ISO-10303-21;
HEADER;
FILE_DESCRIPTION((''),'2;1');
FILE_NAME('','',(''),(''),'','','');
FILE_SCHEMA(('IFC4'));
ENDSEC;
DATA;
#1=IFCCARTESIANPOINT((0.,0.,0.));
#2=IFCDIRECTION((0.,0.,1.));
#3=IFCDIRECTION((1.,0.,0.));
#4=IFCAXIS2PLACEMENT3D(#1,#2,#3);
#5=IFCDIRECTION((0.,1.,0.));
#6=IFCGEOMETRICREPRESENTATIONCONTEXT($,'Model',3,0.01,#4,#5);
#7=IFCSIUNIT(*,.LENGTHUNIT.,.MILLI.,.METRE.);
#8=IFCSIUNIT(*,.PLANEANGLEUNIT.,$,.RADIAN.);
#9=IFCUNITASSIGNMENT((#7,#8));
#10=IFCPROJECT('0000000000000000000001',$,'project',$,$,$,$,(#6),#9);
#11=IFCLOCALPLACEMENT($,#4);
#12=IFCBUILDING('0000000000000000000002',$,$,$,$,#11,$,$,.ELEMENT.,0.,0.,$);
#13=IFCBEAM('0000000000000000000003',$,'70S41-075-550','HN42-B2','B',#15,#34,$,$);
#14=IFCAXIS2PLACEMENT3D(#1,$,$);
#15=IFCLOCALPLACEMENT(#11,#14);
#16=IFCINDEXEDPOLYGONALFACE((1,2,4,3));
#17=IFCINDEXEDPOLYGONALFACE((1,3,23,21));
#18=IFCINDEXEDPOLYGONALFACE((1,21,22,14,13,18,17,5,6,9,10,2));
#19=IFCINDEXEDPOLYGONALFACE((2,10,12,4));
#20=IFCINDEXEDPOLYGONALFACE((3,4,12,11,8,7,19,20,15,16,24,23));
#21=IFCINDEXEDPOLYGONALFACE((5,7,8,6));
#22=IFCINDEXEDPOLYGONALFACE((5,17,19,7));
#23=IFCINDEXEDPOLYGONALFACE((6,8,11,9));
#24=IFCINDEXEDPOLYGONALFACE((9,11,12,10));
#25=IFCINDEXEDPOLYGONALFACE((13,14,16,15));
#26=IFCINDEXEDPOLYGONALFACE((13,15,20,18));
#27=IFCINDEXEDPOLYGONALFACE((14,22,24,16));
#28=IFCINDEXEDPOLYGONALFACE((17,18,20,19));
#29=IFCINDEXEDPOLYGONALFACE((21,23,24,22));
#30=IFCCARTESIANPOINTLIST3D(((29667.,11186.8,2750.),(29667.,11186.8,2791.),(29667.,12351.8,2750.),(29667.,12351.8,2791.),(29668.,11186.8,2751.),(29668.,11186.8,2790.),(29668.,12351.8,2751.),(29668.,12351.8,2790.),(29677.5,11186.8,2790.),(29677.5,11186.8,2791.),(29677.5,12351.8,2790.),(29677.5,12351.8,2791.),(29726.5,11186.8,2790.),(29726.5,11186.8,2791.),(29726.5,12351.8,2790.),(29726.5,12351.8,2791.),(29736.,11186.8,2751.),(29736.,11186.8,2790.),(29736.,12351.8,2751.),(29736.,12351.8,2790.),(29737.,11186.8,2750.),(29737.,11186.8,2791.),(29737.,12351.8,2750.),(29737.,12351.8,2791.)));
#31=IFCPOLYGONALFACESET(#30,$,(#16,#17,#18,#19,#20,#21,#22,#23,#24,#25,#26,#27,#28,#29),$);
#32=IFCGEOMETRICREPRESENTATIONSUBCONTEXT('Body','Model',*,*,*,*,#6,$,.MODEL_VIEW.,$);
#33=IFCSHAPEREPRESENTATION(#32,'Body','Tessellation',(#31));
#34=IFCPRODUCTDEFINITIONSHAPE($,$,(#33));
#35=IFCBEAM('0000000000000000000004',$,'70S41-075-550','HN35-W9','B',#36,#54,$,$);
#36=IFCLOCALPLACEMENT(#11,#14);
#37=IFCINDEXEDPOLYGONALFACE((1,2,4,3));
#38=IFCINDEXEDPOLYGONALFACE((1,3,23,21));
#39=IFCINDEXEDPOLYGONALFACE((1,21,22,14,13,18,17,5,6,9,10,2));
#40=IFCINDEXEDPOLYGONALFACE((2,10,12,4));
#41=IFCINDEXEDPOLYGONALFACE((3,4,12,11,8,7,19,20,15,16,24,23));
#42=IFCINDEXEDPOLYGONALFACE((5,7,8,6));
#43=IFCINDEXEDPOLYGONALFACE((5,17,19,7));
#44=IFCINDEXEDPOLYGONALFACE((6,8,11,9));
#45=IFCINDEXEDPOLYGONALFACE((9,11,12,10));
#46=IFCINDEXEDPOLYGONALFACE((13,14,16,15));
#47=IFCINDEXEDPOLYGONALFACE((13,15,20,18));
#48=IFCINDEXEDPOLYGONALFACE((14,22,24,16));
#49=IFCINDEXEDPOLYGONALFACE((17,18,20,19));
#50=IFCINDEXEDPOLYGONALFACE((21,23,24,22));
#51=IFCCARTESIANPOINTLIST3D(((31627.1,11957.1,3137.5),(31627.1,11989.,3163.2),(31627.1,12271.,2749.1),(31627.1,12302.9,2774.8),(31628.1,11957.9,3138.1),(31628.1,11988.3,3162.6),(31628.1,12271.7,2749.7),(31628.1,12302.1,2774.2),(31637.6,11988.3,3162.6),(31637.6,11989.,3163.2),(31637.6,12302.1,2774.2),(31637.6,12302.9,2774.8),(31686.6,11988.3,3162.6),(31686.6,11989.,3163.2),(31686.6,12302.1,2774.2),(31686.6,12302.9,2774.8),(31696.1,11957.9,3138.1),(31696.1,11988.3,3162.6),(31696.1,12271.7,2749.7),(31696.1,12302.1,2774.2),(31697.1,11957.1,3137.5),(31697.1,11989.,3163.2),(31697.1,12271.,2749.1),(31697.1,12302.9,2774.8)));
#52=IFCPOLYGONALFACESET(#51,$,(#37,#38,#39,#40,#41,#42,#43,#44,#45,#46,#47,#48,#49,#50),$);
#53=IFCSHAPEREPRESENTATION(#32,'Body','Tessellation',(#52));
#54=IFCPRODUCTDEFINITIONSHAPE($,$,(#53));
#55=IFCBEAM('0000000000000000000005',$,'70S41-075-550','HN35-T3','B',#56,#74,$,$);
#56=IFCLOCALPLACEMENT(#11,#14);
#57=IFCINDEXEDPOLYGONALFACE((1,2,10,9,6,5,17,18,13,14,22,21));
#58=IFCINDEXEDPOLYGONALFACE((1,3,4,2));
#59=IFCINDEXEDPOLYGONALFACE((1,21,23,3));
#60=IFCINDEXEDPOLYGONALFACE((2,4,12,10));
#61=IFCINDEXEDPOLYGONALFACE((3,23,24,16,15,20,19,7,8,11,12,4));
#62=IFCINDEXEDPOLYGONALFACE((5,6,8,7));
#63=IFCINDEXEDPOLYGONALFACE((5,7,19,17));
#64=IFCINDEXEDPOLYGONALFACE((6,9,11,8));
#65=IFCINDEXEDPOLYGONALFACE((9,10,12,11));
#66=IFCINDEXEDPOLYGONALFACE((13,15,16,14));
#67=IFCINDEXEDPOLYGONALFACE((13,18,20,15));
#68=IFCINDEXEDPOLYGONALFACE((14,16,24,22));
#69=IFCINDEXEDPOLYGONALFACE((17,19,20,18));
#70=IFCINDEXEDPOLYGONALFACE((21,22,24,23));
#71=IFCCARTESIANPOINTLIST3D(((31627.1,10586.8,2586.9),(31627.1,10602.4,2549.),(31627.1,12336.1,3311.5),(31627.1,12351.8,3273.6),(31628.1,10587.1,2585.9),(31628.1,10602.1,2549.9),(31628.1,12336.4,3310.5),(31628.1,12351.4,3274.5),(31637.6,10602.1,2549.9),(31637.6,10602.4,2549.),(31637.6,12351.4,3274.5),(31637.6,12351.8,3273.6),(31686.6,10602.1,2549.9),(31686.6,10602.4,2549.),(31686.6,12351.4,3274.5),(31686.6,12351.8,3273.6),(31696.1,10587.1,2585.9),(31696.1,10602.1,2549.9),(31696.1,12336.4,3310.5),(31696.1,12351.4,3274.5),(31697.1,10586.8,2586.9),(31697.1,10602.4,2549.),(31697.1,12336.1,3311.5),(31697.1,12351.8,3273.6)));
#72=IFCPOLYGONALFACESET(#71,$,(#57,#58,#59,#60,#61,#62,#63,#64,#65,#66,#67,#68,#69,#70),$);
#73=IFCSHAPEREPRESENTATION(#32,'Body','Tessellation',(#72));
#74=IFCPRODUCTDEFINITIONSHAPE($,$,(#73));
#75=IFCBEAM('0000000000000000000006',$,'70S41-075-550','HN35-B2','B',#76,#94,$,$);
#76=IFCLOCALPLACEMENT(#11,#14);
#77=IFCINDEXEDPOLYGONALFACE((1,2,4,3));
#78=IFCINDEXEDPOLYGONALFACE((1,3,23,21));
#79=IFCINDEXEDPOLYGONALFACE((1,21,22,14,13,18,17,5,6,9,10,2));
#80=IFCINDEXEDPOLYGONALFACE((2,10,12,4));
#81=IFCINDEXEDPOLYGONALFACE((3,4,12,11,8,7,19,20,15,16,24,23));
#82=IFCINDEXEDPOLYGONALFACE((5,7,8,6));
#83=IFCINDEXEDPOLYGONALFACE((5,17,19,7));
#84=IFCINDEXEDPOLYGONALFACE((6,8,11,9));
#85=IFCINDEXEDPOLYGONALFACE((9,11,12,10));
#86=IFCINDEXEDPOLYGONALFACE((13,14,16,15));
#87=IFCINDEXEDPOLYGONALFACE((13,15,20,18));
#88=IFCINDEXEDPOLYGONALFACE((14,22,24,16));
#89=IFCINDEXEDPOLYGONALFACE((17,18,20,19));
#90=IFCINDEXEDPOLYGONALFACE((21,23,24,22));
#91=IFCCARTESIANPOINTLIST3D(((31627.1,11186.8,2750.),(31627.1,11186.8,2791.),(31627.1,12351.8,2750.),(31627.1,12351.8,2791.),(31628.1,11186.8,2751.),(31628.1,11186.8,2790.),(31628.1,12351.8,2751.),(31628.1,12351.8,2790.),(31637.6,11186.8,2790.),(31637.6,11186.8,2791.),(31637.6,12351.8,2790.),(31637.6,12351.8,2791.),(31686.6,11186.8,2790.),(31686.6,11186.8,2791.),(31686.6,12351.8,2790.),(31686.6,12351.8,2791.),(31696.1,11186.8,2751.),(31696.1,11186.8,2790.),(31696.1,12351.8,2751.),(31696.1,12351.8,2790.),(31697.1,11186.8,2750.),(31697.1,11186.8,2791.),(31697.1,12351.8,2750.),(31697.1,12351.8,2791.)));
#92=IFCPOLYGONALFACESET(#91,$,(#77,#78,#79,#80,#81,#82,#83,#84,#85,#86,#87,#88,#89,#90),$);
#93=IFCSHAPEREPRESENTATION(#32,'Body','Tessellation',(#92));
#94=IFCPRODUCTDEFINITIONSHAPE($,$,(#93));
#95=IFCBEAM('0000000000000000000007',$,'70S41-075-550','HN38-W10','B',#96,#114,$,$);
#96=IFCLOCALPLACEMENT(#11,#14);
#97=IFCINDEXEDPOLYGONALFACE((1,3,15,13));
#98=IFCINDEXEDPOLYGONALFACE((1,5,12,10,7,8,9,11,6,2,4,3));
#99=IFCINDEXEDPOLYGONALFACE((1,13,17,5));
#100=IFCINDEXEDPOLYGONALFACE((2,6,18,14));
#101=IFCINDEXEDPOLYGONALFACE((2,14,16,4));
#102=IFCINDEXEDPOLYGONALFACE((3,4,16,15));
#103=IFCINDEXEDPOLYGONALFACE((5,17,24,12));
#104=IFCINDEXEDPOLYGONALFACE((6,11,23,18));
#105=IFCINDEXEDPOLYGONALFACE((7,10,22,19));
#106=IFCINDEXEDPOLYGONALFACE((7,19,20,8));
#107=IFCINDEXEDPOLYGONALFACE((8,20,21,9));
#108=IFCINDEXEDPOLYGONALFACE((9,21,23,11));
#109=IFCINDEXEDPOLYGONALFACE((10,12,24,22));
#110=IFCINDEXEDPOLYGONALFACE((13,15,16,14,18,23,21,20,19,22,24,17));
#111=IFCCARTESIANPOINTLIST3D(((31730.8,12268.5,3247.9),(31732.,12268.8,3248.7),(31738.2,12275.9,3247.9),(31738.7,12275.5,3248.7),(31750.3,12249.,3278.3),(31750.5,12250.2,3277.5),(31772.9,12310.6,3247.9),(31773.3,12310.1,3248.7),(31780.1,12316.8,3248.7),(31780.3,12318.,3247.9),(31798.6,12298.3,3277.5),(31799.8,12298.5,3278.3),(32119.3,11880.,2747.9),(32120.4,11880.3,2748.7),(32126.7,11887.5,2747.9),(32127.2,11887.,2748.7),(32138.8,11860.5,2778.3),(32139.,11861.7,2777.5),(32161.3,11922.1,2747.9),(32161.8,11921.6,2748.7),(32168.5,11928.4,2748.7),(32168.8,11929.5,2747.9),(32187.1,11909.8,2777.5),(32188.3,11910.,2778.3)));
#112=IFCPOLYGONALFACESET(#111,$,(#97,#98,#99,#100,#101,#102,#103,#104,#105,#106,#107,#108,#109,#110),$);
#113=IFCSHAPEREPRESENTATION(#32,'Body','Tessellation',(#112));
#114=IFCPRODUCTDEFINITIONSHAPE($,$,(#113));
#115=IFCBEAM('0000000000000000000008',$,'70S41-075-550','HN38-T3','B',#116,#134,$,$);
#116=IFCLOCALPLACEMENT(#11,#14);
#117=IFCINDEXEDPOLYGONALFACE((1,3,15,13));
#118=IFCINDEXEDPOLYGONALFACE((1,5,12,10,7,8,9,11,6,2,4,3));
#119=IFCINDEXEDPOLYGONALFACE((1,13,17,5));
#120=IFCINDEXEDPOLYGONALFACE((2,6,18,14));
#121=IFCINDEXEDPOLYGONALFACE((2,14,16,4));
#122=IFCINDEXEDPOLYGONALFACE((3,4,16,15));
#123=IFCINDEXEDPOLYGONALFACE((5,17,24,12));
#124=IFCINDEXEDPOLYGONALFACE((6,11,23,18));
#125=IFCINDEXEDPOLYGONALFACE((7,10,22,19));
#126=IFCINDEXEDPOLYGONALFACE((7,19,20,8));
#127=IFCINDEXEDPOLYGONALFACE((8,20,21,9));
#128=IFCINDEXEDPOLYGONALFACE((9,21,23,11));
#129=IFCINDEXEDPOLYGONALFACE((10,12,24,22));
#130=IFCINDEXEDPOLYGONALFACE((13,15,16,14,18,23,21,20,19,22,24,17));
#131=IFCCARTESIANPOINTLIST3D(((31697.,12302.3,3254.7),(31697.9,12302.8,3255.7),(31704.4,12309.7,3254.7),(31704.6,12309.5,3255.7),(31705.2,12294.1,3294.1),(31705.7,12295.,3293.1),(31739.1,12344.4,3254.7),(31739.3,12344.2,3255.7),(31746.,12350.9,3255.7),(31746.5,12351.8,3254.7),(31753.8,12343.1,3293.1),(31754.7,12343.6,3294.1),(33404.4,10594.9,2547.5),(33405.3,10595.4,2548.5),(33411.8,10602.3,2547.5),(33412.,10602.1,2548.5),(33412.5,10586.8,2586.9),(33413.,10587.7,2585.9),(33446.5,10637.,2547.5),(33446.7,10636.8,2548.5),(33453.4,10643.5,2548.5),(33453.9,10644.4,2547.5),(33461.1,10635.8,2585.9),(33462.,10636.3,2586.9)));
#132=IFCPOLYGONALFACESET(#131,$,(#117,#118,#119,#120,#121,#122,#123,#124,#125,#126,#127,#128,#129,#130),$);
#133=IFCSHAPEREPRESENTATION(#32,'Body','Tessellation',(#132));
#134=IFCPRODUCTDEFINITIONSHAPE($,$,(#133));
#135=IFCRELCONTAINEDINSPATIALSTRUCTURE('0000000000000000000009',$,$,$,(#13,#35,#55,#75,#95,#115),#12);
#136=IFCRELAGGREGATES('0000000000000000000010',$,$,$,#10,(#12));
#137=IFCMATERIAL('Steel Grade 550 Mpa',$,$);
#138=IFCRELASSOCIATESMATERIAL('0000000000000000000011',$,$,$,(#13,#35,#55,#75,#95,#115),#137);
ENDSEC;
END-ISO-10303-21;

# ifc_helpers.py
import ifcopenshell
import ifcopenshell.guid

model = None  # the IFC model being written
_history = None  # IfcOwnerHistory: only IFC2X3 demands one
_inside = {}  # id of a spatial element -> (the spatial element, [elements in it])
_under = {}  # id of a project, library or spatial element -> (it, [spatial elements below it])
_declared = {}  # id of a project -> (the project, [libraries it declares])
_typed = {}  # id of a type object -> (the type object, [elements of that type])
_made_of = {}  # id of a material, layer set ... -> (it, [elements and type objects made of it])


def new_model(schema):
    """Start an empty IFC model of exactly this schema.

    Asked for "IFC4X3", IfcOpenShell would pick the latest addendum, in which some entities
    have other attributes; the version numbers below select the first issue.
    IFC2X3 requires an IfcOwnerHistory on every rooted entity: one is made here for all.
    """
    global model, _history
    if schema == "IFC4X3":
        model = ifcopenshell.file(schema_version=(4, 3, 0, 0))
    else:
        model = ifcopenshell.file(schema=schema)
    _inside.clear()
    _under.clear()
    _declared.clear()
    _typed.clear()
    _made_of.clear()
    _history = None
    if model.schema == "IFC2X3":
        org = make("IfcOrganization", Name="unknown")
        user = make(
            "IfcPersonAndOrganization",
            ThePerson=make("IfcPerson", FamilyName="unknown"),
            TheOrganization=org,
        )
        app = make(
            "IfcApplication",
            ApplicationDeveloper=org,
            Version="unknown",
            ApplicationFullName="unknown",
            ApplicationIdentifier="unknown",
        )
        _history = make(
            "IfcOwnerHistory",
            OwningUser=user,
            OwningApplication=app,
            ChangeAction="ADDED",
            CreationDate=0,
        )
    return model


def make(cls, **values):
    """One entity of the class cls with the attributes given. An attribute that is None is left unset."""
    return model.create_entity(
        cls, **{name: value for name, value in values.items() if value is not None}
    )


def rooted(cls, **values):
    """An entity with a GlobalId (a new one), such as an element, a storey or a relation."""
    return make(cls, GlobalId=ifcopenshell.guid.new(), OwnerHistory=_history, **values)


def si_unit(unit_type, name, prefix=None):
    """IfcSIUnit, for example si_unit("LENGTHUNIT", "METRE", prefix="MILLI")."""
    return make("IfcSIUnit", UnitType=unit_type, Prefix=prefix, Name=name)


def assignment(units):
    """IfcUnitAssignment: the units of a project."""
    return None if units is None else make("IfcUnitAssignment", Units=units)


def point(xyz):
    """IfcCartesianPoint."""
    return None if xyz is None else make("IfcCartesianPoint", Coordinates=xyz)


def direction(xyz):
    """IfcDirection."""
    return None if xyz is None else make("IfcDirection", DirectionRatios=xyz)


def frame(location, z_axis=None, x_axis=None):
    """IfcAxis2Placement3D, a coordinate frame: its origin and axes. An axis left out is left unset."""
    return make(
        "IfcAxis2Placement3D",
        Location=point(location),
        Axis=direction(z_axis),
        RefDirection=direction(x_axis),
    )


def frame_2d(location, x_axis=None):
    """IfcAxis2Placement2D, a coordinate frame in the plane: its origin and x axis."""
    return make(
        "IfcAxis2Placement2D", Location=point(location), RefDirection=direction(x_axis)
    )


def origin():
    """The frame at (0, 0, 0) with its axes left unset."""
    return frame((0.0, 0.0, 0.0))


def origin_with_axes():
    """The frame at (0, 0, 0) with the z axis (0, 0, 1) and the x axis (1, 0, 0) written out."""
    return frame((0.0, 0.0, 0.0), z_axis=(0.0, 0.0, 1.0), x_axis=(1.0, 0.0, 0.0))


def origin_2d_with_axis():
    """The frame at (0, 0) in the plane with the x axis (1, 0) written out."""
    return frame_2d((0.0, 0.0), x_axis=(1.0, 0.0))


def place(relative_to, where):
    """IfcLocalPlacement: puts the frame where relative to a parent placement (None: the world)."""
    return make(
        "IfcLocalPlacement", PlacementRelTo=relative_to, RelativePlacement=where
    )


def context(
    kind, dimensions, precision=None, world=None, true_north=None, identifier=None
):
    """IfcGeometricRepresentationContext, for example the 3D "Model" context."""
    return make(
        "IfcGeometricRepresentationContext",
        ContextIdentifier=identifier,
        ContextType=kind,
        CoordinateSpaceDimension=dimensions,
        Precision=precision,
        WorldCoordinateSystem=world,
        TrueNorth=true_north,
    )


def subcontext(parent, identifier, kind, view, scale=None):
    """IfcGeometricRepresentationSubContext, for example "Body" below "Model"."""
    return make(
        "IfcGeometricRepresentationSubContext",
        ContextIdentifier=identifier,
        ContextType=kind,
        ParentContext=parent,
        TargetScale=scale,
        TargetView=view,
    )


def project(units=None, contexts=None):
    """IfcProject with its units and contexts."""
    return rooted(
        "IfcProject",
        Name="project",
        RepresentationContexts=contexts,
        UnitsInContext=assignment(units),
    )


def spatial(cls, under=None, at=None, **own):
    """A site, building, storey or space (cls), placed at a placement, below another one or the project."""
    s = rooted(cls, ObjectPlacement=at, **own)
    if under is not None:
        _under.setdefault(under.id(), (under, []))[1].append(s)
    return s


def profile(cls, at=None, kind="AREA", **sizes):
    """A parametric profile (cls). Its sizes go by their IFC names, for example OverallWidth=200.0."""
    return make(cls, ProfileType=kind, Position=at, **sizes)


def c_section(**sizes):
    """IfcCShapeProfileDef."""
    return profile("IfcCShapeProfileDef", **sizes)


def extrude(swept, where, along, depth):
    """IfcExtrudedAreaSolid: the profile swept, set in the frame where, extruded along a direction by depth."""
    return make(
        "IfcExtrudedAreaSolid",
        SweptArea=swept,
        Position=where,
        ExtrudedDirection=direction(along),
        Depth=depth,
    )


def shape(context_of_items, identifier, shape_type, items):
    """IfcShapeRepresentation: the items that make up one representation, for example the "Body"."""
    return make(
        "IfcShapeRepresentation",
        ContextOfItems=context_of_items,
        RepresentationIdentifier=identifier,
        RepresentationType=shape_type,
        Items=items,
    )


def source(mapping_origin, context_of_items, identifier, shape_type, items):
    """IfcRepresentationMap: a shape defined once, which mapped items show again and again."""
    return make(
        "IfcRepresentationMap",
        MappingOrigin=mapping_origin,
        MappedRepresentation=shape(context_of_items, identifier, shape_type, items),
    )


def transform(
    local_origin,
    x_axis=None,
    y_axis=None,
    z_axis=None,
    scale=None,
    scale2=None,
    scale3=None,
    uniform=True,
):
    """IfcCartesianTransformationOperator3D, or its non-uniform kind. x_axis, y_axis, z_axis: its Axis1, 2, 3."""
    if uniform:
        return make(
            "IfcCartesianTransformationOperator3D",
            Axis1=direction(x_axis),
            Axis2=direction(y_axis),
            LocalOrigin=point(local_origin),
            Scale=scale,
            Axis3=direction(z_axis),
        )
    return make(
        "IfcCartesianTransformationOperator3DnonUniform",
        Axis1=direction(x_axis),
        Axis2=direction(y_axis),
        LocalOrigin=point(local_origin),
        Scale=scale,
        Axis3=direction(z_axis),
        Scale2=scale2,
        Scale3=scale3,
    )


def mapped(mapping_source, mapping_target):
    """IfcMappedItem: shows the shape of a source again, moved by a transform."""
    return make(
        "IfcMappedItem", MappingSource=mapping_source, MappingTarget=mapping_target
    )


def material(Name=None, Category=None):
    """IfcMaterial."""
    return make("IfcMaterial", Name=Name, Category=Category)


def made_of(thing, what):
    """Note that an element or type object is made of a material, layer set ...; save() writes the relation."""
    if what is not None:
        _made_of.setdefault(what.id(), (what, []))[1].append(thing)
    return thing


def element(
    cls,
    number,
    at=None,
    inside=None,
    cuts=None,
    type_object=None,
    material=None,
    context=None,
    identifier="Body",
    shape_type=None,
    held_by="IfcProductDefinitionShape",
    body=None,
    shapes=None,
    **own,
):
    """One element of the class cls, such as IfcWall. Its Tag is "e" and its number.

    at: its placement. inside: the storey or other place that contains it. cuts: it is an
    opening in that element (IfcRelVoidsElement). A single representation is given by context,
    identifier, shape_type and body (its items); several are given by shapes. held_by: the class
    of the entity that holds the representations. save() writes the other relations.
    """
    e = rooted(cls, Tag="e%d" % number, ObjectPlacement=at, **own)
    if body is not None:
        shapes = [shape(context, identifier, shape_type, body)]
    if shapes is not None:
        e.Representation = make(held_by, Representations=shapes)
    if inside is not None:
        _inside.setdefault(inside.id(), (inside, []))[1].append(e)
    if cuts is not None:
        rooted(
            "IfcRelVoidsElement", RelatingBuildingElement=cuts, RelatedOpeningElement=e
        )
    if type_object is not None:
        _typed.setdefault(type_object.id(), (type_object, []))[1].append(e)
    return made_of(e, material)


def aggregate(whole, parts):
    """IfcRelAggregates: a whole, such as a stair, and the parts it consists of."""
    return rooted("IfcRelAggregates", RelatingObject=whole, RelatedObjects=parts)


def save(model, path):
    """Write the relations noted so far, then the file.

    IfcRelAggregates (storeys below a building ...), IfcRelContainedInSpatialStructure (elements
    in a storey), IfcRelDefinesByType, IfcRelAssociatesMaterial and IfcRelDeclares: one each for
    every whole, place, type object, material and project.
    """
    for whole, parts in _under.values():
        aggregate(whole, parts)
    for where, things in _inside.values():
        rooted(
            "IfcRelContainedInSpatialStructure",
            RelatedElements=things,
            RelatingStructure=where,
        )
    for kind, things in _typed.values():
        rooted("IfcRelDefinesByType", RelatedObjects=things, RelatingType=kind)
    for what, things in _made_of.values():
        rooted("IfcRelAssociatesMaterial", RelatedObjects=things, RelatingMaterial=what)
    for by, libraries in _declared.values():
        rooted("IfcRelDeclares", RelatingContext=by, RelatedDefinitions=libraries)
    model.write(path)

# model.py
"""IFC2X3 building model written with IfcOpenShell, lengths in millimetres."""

from ifc_helpers import new_model, si_unit, direction, frame, origin, origin_with_axes, origin_2d_with_axis, place, context, subcontext, project, spatial, c_section, extrude, source, transform, mapped, material, element, save


model = new_model("IFC2X3")

# Units and contexts
model_context = context("Model", 3, precision=0.01, world=origin_with_axes(), true_north=direction((0.0, 1.0, 0.0)))
body_context = subcontext(model_context, "Body", "Model", "MODEL_VIEW")
ifc_project = project(units=[si_unit("LENGTHUNIT", "METRE", prefix="MILLI"), si_unit("PLANEANGLEUNIT", "RADIAN")], contexts=[model_context])

# Building
building_placement = place(None, origin_with_axes())
building = spatial("IfcBuilding", under=ifc_project, at=building_placement, CompositionType="ELEMENT", ElevationOfRefHeight=0.0, ElevationOfTerrain=0.0)

# Shared definitions
ifc_material = material(Name="Steel Grade 550 Mpa")

# Beams
shared_shape_1 = source(origin(), body_context, "Body", "SweptSolid", [
    extrude(c_section(Depth=70.0, Width=41.0, WallThickness=1.0, Girth=10.5, at=origin_2d_with_axis()), origin_with_axes(), (0.0, 0.0, 1.0), 1165.0),
])
beam_1_placement = place(None, frame((29702.0, 11186.8, 2770.5), z_axis=(0.0, 1.0, 0.0), x_axis=(0.0, 0.0, 1.0)))
element("IfcBeam", 1, at=beam_1_placement, inside=building, material=ifc_material, Name="70S41-075-550", Description="HN42-B2", ObjectType="B", context=body_context, shape_type="MappedRepresentation", body=[
    mapped(shared_shape_1, transform((0.0, 0.0, 0.0), scale=1.0)),
])
shared_shape_2 = source(origin(), body_context, "Body", "SweptSolid", [
    extrude(c_section(Depth=70.0, Width=41.0, WallThickness=1.0, Girth=10.5, at=origin_2d_with_axis()), origin_with_axes(), (0.0, 0.0, 1.0), 499.3),
])
beam_2_placement = place(None, frame((31662.1, 11973.1, 3150.3), z_axis=(0.0, 0.628483, -0.777823), x_axis=(0.0, 0.777823, 0.628483)))
element("IfcBeam", 2, at=beam_2_placement, inside=building, material=ifc_material, Name="70S41-075-550", Description="HN35-W9", ObjectType="B", context=body_context, shape_type="MappedRepresentation", body=[
    mapped(shared_shape_2, transform((0.0, 0.0, 0.0), scale=1.0)),
])
shared_shape_3 = source(origin(), body_context, "Body", "SweptSolid", [
    extrude(c_section(Depth=70.0, Width=41.0, WallThickness=1.0, Girth=10.5, at=origin_2d_with_axis()), origin_with_axes(), (0.0, 0.0, 1.0), 1893.4),
])
beam_3_placement = place(None, frame((31662.1, 12343.9, 3292.5), z_axis=(0.0, -0.92388, -0.382683), x_axis=(0.0, 0.382683, -0.92388)))
element("IfcBeam", 3, at=beam_3_placement, inside=building, material=ifc_material, Name="70S41-075-550", Description="HN35-T3", ObjectType="B", context=body_context, shape_type="MappedRepresentation", body=[
    mapped(shared_shape_3, transform((0.0, 0.0, 0.0), scale=1.0)),
])
shared_shape_4 = source(origin(), body_context, "Body", "SweptSolid", [
    extrude(c_section(Depth=70.0, Width=41.0, WallThickness=1.0, Girth=10.5, at=origin_2d_with_axis()), origin_with_axes(), (0.0, 0.0, 1.0), 1165.0),
])
beam_4_placement = place(None, frame((31662.1, 11186.8, 2770.5), z_axis=(0.0, 1.0, 0.0), x_axis=(0.0, 0.0, 1.0)))
element("IfcBeam", 4, at=beam_4_placement, inside=building, material=ifc_material, Name="70S41-075-550", Description="HN35-B2", ObjectType="B", context=body_context, shape_type="MappedRepresentation", body=[
    mapped(shared_shape_4, transform((0.0, 0.0, 0.0), scale=1.0)),
])
shared_shape_5 = source(origin(), body_context, "Body", "SweptSolid", [
    extrude(c_section(Depth=70.0, Width=41.0, WallThickness=1.0, Girth=10.5, at=origin_2d_with_axis()), origin_with_axes(), (0.0, 0.0, 1.0), 742.9),
])
beam_5_placement = place(None, frame((31765.3, 12283.5, 3263.1), z_axis=(0.522949, -0.522949, -0.673089), x_axis=(-0.475946, 0.475945, -0.739562)))
element("IfcBeam", 5, at=beam_5_placement, inside=building, material=ifc_material, Name="70S41-075-550", Description="HN38-W10", ObjectType="B", context=body_context, shape_type="MappedRepresentation", body=[
    mapped(shared_shape_5, transform((0.0, 0.0, 0.0), scale=1.0)),
])
shared_shape_6 = source(origin(), body_context, "Body", "SweptSolid", [
    extrude(c_section(Depth=70.0, Width=41.0, WallThickness=1.0, Girth=10.5, at=origin_2d_with_axis()), origin_with_axes(), (0.0, 0.0, 1.0), 2516.0),
])
beam_6_placement = place(None, frame((31725.8, 12323.0, 3274.4), z_axis=(0.678598, -0.678598, -0.281085), x_axis=(-0.198758, 0.198757, -0.959683)))
element("IfcBeam", 6, at=beam_6_placement, inside=building, material=ifc_material, Name="70S41-075-550", Description="HN38-T3", ObjectType="B", context=body_context, shape_type="MappedRepresentation", body=[
    mapped(shared_shape_6, transform((0.0, 0.0, 0.0), scale=1.0)),
])

save(model, "model.ifc")
